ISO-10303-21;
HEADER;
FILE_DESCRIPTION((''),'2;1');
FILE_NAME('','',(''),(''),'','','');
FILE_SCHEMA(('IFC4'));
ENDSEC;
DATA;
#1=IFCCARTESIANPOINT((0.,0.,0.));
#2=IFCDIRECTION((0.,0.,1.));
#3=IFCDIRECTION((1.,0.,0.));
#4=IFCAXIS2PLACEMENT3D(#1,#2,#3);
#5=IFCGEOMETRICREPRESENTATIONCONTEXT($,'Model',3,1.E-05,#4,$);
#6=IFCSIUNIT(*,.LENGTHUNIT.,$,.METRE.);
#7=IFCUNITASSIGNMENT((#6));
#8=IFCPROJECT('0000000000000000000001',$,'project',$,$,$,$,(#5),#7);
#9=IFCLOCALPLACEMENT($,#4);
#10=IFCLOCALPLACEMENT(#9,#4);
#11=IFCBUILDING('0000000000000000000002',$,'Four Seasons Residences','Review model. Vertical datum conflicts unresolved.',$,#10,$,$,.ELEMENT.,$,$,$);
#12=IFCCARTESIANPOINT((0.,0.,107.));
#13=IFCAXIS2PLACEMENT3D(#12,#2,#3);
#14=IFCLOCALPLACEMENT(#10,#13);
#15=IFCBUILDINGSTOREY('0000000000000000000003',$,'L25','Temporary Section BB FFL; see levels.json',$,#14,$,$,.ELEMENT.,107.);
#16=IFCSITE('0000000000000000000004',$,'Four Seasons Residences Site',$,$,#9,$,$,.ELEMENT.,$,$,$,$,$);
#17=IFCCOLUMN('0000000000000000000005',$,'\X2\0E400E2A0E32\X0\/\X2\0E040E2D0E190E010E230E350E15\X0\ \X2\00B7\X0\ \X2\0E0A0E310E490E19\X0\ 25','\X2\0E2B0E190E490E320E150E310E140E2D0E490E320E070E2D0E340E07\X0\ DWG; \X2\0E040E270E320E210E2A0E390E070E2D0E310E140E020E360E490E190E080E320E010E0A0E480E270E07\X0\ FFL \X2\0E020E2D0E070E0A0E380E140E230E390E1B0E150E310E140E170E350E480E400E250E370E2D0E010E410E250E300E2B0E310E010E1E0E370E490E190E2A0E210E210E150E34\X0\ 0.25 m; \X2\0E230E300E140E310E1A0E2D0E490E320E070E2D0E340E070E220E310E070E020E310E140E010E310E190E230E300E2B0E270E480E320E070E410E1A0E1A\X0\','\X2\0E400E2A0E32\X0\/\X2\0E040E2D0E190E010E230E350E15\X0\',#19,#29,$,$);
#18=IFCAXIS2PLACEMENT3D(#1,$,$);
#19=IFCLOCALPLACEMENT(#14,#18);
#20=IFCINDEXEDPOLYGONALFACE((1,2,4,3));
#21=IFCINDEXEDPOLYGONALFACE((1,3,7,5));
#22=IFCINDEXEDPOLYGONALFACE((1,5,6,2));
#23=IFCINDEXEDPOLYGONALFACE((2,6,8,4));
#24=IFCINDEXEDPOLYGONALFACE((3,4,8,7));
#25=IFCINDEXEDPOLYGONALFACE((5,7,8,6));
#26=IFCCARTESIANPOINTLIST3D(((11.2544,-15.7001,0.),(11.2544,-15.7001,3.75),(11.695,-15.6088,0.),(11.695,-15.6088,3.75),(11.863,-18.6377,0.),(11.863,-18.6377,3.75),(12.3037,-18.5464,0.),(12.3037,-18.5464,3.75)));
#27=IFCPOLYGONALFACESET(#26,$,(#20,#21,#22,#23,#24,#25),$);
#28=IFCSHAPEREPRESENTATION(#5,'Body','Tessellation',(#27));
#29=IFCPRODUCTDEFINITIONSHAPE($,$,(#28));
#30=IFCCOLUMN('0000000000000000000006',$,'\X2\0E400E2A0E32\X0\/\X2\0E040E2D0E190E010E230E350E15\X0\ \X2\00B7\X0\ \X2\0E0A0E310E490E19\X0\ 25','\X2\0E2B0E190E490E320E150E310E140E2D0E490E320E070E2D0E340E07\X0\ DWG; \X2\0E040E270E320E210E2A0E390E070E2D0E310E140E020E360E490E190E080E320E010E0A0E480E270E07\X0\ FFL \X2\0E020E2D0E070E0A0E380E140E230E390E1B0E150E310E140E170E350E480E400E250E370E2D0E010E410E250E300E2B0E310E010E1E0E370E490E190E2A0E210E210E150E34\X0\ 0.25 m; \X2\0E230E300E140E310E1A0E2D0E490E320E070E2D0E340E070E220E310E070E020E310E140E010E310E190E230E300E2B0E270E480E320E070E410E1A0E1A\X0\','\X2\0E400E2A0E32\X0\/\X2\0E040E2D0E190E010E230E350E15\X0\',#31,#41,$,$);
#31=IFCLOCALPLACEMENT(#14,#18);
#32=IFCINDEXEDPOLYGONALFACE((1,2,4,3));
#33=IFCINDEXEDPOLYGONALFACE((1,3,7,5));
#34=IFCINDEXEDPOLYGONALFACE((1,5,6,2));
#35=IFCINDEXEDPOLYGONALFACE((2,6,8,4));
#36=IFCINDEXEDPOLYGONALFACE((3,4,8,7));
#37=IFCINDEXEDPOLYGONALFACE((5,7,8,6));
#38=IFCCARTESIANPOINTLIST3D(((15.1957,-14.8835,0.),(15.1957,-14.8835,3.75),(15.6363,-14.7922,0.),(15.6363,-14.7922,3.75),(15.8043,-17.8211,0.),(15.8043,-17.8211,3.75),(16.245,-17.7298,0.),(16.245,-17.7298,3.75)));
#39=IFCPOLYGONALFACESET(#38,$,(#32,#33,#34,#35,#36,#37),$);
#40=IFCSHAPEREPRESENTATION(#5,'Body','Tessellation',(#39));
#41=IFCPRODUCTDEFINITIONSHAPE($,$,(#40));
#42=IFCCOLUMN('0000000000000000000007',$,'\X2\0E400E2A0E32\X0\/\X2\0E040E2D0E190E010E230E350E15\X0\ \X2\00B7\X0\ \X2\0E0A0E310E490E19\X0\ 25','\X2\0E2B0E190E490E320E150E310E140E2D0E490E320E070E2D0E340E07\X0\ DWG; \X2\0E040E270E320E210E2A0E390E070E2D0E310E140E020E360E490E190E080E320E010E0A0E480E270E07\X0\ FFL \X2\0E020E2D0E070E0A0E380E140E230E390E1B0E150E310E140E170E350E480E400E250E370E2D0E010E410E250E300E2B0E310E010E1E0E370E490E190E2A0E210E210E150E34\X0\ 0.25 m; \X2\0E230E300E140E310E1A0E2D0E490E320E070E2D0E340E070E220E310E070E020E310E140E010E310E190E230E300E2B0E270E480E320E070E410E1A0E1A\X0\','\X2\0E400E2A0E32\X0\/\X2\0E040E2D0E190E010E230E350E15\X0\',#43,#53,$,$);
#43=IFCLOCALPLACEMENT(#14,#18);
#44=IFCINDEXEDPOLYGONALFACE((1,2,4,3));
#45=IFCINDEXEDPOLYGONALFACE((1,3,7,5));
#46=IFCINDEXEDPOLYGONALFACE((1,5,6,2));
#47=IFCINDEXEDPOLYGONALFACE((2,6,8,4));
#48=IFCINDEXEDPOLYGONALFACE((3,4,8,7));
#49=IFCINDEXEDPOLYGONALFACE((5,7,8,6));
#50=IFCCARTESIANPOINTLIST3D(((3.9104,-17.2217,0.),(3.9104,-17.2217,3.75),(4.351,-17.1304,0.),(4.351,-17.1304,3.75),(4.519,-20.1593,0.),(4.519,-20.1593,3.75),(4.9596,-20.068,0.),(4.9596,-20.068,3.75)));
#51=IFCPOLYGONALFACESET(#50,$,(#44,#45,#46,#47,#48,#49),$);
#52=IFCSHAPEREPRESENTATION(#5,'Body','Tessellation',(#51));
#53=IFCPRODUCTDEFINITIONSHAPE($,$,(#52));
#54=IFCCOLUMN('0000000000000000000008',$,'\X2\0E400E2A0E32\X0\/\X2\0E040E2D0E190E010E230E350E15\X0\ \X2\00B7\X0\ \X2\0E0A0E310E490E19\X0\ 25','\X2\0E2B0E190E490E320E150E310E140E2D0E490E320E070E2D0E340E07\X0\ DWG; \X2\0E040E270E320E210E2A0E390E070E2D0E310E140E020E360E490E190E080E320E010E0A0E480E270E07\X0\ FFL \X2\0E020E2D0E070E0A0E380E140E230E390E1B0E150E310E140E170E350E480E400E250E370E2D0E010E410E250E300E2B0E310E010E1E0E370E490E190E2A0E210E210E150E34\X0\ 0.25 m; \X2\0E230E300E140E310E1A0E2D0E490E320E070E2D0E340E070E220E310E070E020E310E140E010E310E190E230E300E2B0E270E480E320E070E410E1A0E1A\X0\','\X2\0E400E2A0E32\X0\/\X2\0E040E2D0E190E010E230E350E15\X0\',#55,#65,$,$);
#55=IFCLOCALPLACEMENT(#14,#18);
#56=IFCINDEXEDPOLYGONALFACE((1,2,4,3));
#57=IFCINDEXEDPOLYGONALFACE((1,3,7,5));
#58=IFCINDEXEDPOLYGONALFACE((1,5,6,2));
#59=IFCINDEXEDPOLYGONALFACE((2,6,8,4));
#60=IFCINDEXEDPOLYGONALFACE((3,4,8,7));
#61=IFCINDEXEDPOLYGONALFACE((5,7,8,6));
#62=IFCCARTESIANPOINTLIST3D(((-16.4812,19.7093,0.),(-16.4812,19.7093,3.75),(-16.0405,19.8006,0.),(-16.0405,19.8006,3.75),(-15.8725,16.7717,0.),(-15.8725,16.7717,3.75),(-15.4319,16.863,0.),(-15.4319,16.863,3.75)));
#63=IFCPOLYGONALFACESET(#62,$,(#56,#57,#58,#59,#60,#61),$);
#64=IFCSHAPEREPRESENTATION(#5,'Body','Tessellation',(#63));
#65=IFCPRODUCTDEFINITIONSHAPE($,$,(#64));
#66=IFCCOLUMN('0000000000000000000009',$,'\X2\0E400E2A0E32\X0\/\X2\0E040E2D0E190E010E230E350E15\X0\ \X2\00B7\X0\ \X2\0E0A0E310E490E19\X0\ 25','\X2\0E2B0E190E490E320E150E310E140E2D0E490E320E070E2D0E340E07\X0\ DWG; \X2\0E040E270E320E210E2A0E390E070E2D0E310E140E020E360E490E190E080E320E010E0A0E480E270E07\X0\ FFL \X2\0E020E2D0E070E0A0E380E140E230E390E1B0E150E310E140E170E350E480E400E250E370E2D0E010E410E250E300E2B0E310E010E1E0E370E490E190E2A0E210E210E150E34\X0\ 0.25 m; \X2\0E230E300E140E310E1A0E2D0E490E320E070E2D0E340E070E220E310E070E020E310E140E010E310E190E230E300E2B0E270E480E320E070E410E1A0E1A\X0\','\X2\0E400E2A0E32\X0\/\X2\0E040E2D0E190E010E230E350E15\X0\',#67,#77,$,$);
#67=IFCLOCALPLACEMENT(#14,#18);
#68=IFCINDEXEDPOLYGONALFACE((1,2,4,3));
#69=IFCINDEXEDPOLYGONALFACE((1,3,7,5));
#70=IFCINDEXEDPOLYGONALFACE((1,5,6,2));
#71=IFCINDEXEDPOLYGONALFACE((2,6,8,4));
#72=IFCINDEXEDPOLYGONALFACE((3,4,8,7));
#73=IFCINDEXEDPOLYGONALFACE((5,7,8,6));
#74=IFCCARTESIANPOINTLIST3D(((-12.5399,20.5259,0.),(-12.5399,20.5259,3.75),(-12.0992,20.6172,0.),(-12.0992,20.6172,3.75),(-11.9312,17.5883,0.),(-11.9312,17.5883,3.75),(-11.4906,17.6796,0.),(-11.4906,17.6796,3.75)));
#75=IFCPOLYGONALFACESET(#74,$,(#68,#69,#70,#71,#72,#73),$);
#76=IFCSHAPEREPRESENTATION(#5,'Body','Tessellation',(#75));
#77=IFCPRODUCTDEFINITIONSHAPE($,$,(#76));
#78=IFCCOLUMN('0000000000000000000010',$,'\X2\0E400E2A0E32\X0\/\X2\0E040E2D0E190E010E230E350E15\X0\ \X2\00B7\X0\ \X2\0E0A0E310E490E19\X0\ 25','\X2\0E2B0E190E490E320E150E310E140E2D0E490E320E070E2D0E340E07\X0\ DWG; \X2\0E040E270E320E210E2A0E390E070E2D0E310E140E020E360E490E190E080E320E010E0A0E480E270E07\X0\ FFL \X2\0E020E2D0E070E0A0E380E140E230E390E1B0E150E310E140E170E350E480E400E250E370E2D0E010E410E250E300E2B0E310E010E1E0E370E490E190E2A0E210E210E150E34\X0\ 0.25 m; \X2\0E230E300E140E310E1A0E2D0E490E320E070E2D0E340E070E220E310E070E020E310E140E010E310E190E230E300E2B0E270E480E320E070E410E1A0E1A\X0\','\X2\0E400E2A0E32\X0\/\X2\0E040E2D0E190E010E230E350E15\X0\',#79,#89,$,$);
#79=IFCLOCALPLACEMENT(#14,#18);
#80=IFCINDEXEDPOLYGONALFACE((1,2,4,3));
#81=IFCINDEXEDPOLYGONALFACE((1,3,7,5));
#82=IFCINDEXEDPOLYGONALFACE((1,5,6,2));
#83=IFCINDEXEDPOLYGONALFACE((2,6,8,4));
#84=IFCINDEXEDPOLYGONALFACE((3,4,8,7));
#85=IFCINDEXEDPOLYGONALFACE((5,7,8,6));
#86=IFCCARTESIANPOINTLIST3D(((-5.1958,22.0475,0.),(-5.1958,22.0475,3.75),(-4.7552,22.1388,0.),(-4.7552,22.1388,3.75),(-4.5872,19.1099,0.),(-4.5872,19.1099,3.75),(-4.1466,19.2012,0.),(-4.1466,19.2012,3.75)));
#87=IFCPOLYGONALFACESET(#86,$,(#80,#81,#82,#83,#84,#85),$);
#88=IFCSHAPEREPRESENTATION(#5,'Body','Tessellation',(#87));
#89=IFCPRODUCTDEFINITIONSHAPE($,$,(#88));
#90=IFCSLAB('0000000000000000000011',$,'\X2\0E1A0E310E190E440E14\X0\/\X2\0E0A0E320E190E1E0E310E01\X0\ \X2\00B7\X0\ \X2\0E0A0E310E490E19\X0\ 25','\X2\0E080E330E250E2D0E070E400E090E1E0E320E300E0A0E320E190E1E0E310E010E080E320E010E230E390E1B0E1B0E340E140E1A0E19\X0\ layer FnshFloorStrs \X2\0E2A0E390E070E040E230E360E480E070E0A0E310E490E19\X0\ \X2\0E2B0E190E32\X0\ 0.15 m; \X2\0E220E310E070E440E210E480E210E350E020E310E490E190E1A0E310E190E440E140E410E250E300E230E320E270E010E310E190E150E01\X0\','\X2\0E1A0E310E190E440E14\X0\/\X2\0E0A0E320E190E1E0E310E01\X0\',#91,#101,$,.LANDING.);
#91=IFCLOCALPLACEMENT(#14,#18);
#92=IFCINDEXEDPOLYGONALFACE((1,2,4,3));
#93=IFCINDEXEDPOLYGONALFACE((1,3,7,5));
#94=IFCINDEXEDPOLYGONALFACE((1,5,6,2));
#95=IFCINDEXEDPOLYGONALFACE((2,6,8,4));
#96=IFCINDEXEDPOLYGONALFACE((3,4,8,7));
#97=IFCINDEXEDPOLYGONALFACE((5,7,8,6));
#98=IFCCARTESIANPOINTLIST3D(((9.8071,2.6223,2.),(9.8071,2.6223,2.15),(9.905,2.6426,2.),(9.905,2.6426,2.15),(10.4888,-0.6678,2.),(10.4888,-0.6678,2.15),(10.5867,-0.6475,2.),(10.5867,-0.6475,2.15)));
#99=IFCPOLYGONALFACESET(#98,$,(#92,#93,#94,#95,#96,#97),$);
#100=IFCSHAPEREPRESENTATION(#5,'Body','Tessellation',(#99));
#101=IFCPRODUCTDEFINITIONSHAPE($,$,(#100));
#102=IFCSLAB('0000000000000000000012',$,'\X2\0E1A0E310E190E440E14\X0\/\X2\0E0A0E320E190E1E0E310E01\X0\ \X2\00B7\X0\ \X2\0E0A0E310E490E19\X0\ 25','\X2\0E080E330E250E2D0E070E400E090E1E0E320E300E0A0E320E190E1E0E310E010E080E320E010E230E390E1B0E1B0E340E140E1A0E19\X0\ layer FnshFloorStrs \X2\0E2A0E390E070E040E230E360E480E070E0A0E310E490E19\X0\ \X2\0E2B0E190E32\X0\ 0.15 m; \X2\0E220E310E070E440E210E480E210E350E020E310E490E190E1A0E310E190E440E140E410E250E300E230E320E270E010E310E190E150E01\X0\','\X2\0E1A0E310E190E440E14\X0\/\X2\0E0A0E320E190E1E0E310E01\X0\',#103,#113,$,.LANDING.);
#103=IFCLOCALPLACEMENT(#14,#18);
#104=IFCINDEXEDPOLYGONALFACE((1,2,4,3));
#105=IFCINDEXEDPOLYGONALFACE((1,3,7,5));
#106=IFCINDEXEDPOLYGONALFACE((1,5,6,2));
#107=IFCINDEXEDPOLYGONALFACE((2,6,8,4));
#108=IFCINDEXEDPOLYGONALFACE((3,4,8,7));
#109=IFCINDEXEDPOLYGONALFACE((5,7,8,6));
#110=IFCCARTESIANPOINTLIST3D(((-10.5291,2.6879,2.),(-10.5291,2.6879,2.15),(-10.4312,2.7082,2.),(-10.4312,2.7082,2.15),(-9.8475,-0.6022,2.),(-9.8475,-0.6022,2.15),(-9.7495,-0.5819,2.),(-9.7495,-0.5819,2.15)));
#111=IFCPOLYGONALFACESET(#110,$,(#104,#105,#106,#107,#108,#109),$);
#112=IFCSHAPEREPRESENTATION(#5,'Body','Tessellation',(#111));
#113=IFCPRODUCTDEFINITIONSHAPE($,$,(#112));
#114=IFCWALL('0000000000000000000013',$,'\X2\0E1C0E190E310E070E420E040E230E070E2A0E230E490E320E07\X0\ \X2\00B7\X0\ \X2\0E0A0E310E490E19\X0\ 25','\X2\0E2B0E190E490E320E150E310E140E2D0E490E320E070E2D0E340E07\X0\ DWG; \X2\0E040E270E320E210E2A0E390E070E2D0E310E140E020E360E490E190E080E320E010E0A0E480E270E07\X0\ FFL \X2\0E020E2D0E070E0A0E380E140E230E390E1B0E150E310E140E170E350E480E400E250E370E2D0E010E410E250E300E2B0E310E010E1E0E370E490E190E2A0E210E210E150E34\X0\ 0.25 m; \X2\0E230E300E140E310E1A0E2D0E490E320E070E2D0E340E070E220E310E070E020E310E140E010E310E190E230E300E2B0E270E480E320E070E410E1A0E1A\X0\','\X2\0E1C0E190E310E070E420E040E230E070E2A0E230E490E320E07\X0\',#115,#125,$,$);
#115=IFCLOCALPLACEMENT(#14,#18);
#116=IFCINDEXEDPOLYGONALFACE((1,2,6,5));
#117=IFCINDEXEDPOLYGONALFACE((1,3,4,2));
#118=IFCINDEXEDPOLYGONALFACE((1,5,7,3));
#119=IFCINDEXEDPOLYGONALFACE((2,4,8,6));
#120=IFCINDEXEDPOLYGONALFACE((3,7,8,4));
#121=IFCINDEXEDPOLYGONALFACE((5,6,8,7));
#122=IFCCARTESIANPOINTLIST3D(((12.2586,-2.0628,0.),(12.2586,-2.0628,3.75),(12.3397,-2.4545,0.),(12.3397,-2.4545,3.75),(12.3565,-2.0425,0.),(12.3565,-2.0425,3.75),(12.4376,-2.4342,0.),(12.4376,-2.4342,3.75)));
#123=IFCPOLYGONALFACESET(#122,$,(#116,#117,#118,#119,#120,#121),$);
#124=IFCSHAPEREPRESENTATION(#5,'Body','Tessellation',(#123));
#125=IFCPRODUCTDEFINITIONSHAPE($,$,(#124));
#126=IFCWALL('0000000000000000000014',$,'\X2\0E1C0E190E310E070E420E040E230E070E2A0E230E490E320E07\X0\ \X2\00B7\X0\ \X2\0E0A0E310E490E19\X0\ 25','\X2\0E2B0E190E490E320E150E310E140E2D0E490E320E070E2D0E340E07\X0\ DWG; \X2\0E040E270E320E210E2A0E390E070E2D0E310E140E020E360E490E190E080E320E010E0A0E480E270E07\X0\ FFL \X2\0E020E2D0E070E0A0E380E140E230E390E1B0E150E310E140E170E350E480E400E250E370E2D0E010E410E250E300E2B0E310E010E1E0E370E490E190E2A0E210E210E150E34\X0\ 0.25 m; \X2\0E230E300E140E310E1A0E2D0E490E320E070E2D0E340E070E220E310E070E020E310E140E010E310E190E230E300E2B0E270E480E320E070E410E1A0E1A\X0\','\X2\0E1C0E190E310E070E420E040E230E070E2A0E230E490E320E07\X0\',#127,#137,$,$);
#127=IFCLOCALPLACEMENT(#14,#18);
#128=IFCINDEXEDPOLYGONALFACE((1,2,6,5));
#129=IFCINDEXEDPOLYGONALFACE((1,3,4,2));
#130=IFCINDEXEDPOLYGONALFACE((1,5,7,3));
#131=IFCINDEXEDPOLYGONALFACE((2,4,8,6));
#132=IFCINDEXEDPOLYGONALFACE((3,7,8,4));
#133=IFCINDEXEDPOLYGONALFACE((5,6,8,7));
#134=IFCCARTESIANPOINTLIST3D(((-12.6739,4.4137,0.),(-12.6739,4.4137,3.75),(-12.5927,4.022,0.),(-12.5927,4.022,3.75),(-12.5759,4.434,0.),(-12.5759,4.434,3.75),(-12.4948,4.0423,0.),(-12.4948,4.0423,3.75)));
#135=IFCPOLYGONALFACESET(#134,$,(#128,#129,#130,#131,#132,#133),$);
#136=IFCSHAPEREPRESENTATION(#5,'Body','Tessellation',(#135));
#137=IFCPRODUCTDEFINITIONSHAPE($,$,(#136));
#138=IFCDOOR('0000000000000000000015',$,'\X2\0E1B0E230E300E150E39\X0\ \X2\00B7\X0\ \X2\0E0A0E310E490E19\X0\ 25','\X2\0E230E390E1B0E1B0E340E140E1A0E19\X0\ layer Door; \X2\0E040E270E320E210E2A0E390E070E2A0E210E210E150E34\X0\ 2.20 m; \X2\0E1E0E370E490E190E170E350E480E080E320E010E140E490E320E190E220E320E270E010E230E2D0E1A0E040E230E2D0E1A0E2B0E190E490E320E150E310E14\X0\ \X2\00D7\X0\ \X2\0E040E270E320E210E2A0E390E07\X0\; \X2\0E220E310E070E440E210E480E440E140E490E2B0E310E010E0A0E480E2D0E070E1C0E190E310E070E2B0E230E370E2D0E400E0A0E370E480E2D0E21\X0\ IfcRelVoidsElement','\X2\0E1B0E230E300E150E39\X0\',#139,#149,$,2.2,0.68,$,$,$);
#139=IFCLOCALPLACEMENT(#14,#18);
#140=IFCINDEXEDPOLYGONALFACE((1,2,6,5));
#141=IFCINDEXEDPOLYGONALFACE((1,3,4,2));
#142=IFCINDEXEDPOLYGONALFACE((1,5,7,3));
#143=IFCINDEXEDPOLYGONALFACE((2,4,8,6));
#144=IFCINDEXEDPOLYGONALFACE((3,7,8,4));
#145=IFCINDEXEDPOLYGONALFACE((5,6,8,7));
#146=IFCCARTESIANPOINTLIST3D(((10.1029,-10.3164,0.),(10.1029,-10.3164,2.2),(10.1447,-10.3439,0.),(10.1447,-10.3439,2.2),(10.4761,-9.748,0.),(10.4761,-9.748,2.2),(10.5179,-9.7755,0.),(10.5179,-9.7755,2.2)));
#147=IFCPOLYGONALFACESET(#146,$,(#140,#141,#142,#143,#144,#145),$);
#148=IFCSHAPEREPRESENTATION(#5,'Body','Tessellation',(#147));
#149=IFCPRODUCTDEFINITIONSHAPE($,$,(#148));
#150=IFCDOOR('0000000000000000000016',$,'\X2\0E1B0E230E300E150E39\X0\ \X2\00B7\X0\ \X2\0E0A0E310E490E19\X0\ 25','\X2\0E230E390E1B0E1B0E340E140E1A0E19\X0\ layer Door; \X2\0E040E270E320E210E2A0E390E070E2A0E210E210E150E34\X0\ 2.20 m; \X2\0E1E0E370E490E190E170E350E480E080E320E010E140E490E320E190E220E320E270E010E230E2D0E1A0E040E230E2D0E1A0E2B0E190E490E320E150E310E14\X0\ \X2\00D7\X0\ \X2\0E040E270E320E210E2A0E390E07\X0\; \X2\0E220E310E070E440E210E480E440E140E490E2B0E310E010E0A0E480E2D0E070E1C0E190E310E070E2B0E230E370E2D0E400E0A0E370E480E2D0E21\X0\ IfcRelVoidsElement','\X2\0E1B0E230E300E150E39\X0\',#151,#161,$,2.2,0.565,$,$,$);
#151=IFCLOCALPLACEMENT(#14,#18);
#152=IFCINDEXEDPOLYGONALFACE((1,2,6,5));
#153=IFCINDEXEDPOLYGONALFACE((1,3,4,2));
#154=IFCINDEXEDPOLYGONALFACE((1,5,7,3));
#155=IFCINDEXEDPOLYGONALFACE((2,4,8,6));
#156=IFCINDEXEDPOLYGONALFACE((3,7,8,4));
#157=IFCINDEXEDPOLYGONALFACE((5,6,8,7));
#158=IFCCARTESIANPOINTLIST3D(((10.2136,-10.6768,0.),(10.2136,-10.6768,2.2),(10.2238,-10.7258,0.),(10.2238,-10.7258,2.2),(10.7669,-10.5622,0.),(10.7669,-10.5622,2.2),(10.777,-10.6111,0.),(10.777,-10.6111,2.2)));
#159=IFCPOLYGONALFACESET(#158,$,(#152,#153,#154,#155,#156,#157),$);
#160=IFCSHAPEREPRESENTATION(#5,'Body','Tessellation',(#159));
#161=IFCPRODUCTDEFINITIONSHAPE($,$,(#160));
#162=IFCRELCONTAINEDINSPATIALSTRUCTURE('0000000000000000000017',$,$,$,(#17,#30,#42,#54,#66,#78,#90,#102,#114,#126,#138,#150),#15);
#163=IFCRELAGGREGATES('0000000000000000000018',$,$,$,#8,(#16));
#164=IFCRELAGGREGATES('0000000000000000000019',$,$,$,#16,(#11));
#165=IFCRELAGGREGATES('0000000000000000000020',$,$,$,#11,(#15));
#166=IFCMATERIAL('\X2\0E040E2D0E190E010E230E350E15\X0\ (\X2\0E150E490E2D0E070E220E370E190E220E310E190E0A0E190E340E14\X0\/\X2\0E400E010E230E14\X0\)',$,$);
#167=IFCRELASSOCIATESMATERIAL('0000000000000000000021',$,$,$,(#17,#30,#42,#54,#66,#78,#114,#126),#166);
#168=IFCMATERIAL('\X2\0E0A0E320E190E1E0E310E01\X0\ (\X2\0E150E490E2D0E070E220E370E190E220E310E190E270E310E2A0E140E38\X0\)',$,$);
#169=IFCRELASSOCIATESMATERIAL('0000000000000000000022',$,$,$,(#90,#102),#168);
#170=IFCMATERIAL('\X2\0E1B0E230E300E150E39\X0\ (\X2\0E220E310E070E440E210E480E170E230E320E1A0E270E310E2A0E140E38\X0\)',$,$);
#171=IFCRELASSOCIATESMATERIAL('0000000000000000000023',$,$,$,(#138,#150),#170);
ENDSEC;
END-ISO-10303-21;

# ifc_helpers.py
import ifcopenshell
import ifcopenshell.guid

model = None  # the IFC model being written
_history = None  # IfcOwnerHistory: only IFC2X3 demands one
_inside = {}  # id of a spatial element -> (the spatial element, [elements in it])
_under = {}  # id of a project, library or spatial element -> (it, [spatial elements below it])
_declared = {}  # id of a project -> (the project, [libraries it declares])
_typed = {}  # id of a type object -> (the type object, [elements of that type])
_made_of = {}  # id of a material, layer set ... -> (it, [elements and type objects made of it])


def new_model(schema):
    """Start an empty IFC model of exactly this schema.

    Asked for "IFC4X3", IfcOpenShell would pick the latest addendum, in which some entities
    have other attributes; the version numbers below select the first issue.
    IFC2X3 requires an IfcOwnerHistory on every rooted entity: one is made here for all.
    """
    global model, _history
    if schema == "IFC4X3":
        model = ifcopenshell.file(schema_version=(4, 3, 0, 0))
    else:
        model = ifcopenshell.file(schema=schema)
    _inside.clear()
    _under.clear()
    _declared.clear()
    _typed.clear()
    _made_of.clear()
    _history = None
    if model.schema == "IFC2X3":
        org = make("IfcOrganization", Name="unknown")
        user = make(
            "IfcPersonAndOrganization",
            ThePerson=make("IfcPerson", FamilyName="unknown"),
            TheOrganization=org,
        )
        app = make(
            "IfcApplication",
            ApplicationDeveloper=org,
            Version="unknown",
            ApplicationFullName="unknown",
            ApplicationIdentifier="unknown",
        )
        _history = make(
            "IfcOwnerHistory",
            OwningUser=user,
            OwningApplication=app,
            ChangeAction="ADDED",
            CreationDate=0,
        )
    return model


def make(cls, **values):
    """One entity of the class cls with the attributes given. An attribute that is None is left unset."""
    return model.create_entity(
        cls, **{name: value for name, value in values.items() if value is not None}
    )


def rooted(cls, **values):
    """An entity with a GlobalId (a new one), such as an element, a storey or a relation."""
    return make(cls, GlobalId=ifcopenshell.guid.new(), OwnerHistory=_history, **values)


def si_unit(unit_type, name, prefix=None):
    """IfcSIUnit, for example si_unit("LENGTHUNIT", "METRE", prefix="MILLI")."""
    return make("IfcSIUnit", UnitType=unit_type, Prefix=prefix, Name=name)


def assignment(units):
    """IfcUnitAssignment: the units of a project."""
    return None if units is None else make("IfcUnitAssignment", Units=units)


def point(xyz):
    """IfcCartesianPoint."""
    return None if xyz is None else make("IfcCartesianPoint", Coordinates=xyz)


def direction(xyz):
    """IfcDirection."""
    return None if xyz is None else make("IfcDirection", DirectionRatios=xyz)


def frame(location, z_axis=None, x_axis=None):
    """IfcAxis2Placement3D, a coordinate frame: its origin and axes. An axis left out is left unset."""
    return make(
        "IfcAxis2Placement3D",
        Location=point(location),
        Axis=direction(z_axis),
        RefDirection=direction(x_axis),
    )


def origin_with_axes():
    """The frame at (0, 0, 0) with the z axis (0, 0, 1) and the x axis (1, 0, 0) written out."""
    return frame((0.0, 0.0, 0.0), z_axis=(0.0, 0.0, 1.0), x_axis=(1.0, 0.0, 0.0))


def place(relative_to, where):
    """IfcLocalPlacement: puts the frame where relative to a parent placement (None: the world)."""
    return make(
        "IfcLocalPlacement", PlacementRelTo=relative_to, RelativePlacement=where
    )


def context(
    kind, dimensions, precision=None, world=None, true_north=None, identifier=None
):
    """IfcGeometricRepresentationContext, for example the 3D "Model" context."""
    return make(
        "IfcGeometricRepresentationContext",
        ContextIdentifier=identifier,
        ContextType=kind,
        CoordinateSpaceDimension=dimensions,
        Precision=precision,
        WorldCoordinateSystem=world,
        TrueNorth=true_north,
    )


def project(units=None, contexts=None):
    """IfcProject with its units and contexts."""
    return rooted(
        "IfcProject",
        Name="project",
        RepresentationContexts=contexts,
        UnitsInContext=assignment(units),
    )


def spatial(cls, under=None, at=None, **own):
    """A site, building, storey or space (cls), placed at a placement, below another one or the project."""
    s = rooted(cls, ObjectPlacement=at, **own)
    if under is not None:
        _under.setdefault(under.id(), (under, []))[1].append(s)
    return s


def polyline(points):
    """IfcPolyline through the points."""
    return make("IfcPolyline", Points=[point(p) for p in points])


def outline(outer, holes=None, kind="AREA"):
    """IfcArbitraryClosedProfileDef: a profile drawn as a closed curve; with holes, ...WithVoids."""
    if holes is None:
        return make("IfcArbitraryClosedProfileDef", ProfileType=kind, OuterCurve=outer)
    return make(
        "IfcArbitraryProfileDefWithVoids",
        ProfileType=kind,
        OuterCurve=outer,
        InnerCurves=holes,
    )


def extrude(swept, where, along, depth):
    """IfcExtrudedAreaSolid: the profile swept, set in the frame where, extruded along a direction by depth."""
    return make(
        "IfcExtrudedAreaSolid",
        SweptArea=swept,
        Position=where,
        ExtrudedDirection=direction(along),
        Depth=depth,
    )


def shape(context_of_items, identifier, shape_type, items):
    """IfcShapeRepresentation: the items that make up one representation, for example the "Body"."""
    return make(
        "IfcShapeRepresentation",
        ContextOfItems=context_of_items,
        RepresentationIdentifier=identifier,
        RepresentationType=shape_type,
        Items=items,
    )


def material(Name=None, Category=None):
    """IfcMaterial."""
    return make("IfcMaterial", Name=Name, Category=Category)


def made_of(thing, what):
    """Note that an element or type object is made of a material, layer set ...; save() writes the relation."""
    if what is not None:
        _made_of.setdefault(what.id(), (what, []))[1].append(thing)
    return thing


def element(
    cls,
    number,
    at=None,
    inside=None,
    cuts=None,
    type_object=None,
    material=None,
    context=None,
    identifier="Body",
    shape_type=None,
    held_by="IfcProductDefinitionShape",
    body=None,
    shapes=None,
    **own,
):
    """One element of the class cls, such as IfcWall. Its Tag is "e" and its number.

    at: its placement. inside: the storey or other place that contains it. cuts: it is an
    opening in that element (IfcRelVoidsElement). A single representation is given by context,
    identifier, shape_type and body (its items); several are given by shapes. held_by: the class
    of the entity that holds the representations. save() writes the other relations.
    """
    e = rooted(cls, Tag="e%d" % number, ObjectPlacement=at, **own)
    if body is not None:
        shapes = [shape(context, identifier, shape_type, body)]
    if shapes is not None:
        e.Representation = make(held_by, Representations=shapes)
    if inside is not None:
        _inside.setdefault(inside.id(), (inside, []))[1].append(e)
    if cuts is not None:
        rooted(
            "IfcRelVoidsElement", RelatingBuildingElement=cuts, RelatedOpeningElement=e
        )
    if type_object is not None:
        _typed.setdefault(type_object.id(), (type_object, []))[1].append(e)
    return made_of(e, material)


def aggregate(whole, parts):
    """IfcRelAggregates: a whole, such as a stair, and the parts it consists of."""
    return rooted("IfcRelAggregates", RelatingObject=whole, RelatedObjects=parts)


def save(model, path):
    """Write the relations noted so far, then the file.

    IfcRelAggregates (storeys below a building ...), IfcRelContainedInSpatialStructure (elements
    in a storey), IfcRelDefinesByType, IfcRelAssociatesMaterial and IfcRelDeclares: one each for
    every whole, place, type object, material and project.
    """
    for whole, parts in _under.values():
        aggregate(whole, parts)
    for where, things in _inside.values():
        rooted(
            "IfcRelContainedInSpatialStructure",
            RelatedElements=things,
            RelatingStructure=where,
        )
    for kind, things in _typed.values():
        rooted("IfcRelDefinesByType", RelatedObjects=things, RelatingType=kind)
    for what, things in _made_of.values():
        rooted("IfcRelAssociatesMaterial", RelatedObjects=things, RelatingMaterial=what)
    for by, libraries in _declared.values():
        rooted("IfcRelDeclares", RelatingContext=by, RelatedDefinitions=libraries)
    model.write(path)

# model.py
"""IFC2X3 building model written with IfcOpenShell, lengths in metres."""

from ifc_helpers import new_model, si_unit, frame, origin_with_axes, place, context, project, spatial, polyline, outline, extrude, material, element, save


model = new_model("IFC2X3")

# Units and contexts
model_context = context("Model", 3, precision=1e-05, world=origin_with_axes())
ifc_project = project(units=[si_unit("LENGTHUNIT", "METRE")], contexts=[model_context])

# Site, building, storey
site_placement = place(None, origin_with_axes())
site = spatial("IfcSite", under=ifc_project, at=site_placement, Name="Four Seasons Residences Site", CompositionType="ELEMENT")
building_placement = place(site_placement, origin_with_axes())
building = spatial("IfcBuilding", under=site, at=building_placement, Name="Four Seasons Residences", Description="Review model. Vertical datum conflicts unresolved.", CompositionType="ELEMENT")
storey_placement = place(building_placement, frame((0.0, 0.0, 107.0), z_axis=(0.0, 0.0, 1.0), x_axis=(1.0, 0.0, 0.0)))
storey = spatial("IfcBuildingStorey", under=building, at=storey_placement, Name="L25", Description="Temporary Section BB FFL; see levels.json", CompositionType="ELEMENT", Elevation=107.0)

# Columns
ifc_material_1 = material(Name="คอนกรีต (ต้องยืนยันชนิด/เกรด)")
column_1_placement = place(storey_placement, origin_with_axes())
element("IfcColumn", 1, at=column_1_placement, inside=storey, material=ifc_material_1, Name="เสา/คอนกรีต · ชั้น 25", Description="หน้าตัดอ้างอิง DWG; ความสูงอัดขึ้นจากช่วง FFL ของชุดรูปตัดที่เลือกและหักพื้นสมมติ 0.25 m; ระดับอ้างอิงยังขัดกันระหว่างแบบ", ObjectType="เสา/คอนกรีต", context=model_context, shape_type="SweptSolid", body=[
    extrude(outline(polyline([(12.3037, -18.5464), (11.863, -18.6377), (11.2544, -15.7001), (11.695, -15.6088), (12.3037, -18.5464)])), origin_with_axes(), (0.0, 0.0, 1.0), 3.75),
])
column_2_placement = place(storey_placement, origin_with_axes())
element("IfcColumn", 2, at=column_2_placement, inside=storey, material=ifc_material_1, Name="เสา/คอนกรีต · ชั้น 25", Description="หน้าตัดอ้างอิง DWG; ความสูงอัดขึ้นจากช่วง FFL ของชุดรูปตัดที่เลือกและหักพื้นสมมติ 0.25 m; ระดับอ้างอิงยังขัดกันระหว่างแบบ", ObjectType="เสา/คอนกรีต", context=model_context, shape_type="SweptSolid", body=[
    extrude(outline(polyline([(16.245, -17.7298), (15.8043, -17.8211), (15.1957, -14.8835), (15.6363, -14.7922), (16.245, -17.7298)])), origin_with_axes(), (0.0, 0.0, 1.0), 3.75),
])
column_3_placement = place(storey_placement, origin_with_axes())
element("IfcColumn", 3, at=column_3_placement, inside=storey, material=ifc_material_1, Name="เสา/คอนกรีต · ชั้น 25", Description="หน้าตัดอ้างอิง DWG; ความสูงอัดขึ้นจากช่วง FFL ของชุดรูปตัดที่เลือกและหักพื้นสมมติ 0.25 m; ระดับอ้างอิงยังขัดกันระหว่างแบบ", ObjectType="เสา/คอนกรีต", context=model_context, shape_type="SweptSolid", body=[
    extrude(outline(polyline([(4.9596, -20.068), (4.519, -20.1593), (3.9104, -17.2217), (4.351, -17.1304), (4.9596, -20.068)])), origin_with_axes(), (0.0, 0.0, 1.0), 3.75),
])
column_4_placement = place(storey_placement, origin_with_axes())
element("IfcColumn", 4, at=column_4_placement, inside=storey, material=ifc_material_1, Name="เสา/คอนกรีต · ชั้น 25", Description="หน้าตัดอ้างอิง DWG; ความสูงอัดขึ้นจากช่วง FFL ของชุดรูปตัดที่เลือกและหักพื้นสมมติ 0.25 m; ระดับอ้างอิงยังขัดกันระหว่างแบบ", ObjectType="เสา/คอนกรีต", context=model_context, shape_type="SweptSolid", body=[
    extrude(outline(polyline([(-15.4319, 16.863), (-15.8725, 16.7717), (-16.4812, 19.7093), (-16.0405, 19.8006), (-15.4319, 16.863)])), origin_with_axes(), (0.0, 0.0, 1.0), 3.75),
])
column_5_placement = place(storey_placement, origin_with_axes())
element("IfcColumn", 5, at=column_5_placement, inside=storey, material=ifc_material_1, Name="เสา/คอนกรีต · ชั้น 25", Description="หน้าตัดอ้างอิง DWG; ความสูงอัดขึ้นจากช่วง FFL ของชุดรูปตัดที่เลือกและหักพื้นสมมติ 0.25 m; ระดับอ้างอิงยังขัดกันระหว่างแบบ", ObjectType="เสา/คอนกรีต", context=model_context, shape_type="SweptSolid", body=[
    extrude(outline(polyline([(-11.4906, 17.6796), (-11.9312, 17.5883), (-12.5399, 20.5259), (-12.0992, 20.6172), (-11.4906, 17.6796)])), origin_with_axes(), (0.0, 0.0, 1.0), 3.75),
])
column_6_placement = place(storey_placement, origin_with_axes())
element("IfcColumn", 6, at=column_6_placement, inside=storey, material=ifc_material_1, Name="เสา/คอนกรีต · ชั้น 25", Description="หน้าตัดอ้างอิง DWG; ความสูงอัดขึ้นจากช่วง FFL ของชุดรูปตัดที่เลือกและหักพื้นสมมติ 0.25 m; ระดับอ้างอิงยังขัดกันระหว่างแบบ", ObjectType="เสา/คอนกรีต", context=model_context, shape_type="SweptSolid", body=[
    extrude(outline(polyline([(-4.1466, 19.2012), (-4.5872, 19.1099), (-5.1958, 22.0475), (-4.7552, 22.1388), (-4.1466, 19.2012)])), origin_with_axes(), (0.0, 0.0, 1.0), 3.75),
])

# Slabs
ifc_material_2 = material(Name="ชานพัก (ต้องยืนยันวัสดุ)")
slab_1_placement = place(storey_placement, origin_with_axes())
element("IfcSlab", 7, at=slab_1_placement, inside=storey, material=ifc_material_2, Name="บันได/ชานพัก · ชั้น 25", Description="จำลองเฉพาะชานพักจากรูปปิดบน layer FnshFloorStrs สูงครึ่งชั้น หนา 0.15 m; ยังไม่มีขั้นบันไดและราวกันตก", ObjectType="บันได/ชานพัก", PredefinedType="LANDING", context=model_context, shape_type="SweptSolid", body=[
    extrude(outline(polyline([(10.5867, -0.6475), (10.4888, -0.6678), (9.8071, 2.6223), (9.905, 2.6426), (10.5867, -0.6475)])), frame((0.0, 0.0, 2.0), z_axis=(0.0, 0.0, 1.0), x_axis=(1.0, 0.0, 0.0)), (0.0, 0.0, 1.0), 0.15),
])
slab_2_placement = place(storey_placement, origin_with_axes())
element("IfcSlab", 8, at=slab_2_placement, inside=storey, material=ifc_material_2, Name="บันได/ชานพัก · ชั้น 25", Description="จำลองเฉพาะชานพักจากรูปปิดบน layer FnshFloorStrs สูงครึ่งชั้น หนา 0.15 m; ยังไม่มีขั้นบันไดและราวกันตก", ObjectType="บันได/ชานพัก", PredefinedType="LANDING", context=model_context, shape_type="SweptSolid", body=[
    extrude(outline(polyline([(-10.5291, 2.6879), (-10.4312, 2.7082), (-9.7495, -0.5819), (-9.8475, -0.6022), (-10.5291, 2.6879)])), frame((0.0, 0.0, 2.0), z_axis=(0.0, 0.0, 1.0), x_axis=(1.0, 0.0, 0.0)), (0.0, 0.0, 1.0), 0.15),
])

# Walls
wall_1_placement = place(storey_placement, origin_with_axes())
element("IfcWall", 9, at=wall_1_placement, inside=storey, material=ifc_material_1, Name="ผนังโครงสร้าง · ชั้น 25", Description="หน้าตัดอ้างอิง DWG; ความสูงอัดขึ้นจากช่วง FFL ของชุดรูปตัดที่เลือกและหักพื้นสมมติ 0.25 m; ระดับอ้างอิงยังขัดกันระหว่างแบบ", ObjectType="ผนังโครงสร้าง", context=model_context, shape_type="SweptSolid", body=[
    extrude(outline(polyline([(12.2586, -2.0628), (12.3397, -2.4545), (12.4376, -2.4342), (12.3565, -2.0425), (12.2586, -2.0628)])), origin_with_axes(), (0.0, 0.0, 1.0), 3.75),
])
wall_2_placement = place(storey_placement, origin_with_axes())
element("IfcWall", 10, at=wall_2_placement, inside=storey, material=ifc_material_1, Name="ผนังโครงสร้าง · ชั้น 25", Description="หน้าตัดอ้างอิง DWG; ความสูงอัดขึ้นจากช่วง FFL ของชุดรูปตัดที่เลือกและหักพื้นสมมติ 0.25 m; ระดับอ้างอิงยังขัดกันระหว่างแบบ", ObjectType="ผนังโครงสร้าง", context=model_context, shape_type="SweptSolid", body=[
    extrude(outline(polyline([(-12.5927, 4.022), (-12.6739, 4.4137), (-12.5759, 4.434), (-12.4948, 4.0423), (-12.5927, 4.022)])), origin_with_axes(), (0.0, 0.0, 1.0), 3.75),
])

# Doors
ifc_material_3 = material(Name="ประตู (ยังไม่ทราบวัสดุ)")
door_1_placement = place(storey_placement, origin_with_axes())
element("IfcDoor", 11, at=door_1_placement, inside=storey, material=ifc_material_3, Name="ประตู · ชั้น 25", Description="รูปปิดบน layer Door; ความสูงสมมติ 2.20 m; พื้นที่จากด้านยาวกรอบครอบหน้าตัด × ความสูง; ยังไม่ได้หักช่องผนังหรือเชื่อม IfcRelVoidsElement", ObjectType="ประตู", OverallHeight=2.2, OverallWidth=0.68, context=model_context, shape_type="SweptSolid", body=[
    extrude(outline(polyline([(10.5179, -9.7755), (10.1447, -10.3439), (10.1029, -10.3164), (10.4761, -9.748), (10.5179, -9.7755)])), origin_with_axes(), (0.0, 0.0, 1.0), 2.2),
])
door_2_placement = place(storey_placement, origin_with_axes())
element("IfcDoor", 12, at=door_2_placement, inside=storey, material=ifc_material_3, Name="ประตู · ชั้น 25", Description="รูปปิดบน layer Door; ความสูงสมมติ 2.20 m; พื้นที่จากด้านยาวกรอบครอบหน้าตัด × ความสูง; ยังไม่ได้หักช่องผนังหรือเชื่อม IfcRelVoidsElement", ObjectType="ประตู", OverallHeight=2.2, OverallWidth=0.565, context=model_context, shape_type="SweptSolid", body=[
    extrude(outline(polyline([(10.7669, -10.5622), (10.2136, -10.6768), (10.2238, -10.7258), (10.777, -10.6111), (10.7669, -10.5622)])), origin_with_axes(), (0.0, 0.0, 1.0), 2.2),
])

save(model, "model.ifc")
